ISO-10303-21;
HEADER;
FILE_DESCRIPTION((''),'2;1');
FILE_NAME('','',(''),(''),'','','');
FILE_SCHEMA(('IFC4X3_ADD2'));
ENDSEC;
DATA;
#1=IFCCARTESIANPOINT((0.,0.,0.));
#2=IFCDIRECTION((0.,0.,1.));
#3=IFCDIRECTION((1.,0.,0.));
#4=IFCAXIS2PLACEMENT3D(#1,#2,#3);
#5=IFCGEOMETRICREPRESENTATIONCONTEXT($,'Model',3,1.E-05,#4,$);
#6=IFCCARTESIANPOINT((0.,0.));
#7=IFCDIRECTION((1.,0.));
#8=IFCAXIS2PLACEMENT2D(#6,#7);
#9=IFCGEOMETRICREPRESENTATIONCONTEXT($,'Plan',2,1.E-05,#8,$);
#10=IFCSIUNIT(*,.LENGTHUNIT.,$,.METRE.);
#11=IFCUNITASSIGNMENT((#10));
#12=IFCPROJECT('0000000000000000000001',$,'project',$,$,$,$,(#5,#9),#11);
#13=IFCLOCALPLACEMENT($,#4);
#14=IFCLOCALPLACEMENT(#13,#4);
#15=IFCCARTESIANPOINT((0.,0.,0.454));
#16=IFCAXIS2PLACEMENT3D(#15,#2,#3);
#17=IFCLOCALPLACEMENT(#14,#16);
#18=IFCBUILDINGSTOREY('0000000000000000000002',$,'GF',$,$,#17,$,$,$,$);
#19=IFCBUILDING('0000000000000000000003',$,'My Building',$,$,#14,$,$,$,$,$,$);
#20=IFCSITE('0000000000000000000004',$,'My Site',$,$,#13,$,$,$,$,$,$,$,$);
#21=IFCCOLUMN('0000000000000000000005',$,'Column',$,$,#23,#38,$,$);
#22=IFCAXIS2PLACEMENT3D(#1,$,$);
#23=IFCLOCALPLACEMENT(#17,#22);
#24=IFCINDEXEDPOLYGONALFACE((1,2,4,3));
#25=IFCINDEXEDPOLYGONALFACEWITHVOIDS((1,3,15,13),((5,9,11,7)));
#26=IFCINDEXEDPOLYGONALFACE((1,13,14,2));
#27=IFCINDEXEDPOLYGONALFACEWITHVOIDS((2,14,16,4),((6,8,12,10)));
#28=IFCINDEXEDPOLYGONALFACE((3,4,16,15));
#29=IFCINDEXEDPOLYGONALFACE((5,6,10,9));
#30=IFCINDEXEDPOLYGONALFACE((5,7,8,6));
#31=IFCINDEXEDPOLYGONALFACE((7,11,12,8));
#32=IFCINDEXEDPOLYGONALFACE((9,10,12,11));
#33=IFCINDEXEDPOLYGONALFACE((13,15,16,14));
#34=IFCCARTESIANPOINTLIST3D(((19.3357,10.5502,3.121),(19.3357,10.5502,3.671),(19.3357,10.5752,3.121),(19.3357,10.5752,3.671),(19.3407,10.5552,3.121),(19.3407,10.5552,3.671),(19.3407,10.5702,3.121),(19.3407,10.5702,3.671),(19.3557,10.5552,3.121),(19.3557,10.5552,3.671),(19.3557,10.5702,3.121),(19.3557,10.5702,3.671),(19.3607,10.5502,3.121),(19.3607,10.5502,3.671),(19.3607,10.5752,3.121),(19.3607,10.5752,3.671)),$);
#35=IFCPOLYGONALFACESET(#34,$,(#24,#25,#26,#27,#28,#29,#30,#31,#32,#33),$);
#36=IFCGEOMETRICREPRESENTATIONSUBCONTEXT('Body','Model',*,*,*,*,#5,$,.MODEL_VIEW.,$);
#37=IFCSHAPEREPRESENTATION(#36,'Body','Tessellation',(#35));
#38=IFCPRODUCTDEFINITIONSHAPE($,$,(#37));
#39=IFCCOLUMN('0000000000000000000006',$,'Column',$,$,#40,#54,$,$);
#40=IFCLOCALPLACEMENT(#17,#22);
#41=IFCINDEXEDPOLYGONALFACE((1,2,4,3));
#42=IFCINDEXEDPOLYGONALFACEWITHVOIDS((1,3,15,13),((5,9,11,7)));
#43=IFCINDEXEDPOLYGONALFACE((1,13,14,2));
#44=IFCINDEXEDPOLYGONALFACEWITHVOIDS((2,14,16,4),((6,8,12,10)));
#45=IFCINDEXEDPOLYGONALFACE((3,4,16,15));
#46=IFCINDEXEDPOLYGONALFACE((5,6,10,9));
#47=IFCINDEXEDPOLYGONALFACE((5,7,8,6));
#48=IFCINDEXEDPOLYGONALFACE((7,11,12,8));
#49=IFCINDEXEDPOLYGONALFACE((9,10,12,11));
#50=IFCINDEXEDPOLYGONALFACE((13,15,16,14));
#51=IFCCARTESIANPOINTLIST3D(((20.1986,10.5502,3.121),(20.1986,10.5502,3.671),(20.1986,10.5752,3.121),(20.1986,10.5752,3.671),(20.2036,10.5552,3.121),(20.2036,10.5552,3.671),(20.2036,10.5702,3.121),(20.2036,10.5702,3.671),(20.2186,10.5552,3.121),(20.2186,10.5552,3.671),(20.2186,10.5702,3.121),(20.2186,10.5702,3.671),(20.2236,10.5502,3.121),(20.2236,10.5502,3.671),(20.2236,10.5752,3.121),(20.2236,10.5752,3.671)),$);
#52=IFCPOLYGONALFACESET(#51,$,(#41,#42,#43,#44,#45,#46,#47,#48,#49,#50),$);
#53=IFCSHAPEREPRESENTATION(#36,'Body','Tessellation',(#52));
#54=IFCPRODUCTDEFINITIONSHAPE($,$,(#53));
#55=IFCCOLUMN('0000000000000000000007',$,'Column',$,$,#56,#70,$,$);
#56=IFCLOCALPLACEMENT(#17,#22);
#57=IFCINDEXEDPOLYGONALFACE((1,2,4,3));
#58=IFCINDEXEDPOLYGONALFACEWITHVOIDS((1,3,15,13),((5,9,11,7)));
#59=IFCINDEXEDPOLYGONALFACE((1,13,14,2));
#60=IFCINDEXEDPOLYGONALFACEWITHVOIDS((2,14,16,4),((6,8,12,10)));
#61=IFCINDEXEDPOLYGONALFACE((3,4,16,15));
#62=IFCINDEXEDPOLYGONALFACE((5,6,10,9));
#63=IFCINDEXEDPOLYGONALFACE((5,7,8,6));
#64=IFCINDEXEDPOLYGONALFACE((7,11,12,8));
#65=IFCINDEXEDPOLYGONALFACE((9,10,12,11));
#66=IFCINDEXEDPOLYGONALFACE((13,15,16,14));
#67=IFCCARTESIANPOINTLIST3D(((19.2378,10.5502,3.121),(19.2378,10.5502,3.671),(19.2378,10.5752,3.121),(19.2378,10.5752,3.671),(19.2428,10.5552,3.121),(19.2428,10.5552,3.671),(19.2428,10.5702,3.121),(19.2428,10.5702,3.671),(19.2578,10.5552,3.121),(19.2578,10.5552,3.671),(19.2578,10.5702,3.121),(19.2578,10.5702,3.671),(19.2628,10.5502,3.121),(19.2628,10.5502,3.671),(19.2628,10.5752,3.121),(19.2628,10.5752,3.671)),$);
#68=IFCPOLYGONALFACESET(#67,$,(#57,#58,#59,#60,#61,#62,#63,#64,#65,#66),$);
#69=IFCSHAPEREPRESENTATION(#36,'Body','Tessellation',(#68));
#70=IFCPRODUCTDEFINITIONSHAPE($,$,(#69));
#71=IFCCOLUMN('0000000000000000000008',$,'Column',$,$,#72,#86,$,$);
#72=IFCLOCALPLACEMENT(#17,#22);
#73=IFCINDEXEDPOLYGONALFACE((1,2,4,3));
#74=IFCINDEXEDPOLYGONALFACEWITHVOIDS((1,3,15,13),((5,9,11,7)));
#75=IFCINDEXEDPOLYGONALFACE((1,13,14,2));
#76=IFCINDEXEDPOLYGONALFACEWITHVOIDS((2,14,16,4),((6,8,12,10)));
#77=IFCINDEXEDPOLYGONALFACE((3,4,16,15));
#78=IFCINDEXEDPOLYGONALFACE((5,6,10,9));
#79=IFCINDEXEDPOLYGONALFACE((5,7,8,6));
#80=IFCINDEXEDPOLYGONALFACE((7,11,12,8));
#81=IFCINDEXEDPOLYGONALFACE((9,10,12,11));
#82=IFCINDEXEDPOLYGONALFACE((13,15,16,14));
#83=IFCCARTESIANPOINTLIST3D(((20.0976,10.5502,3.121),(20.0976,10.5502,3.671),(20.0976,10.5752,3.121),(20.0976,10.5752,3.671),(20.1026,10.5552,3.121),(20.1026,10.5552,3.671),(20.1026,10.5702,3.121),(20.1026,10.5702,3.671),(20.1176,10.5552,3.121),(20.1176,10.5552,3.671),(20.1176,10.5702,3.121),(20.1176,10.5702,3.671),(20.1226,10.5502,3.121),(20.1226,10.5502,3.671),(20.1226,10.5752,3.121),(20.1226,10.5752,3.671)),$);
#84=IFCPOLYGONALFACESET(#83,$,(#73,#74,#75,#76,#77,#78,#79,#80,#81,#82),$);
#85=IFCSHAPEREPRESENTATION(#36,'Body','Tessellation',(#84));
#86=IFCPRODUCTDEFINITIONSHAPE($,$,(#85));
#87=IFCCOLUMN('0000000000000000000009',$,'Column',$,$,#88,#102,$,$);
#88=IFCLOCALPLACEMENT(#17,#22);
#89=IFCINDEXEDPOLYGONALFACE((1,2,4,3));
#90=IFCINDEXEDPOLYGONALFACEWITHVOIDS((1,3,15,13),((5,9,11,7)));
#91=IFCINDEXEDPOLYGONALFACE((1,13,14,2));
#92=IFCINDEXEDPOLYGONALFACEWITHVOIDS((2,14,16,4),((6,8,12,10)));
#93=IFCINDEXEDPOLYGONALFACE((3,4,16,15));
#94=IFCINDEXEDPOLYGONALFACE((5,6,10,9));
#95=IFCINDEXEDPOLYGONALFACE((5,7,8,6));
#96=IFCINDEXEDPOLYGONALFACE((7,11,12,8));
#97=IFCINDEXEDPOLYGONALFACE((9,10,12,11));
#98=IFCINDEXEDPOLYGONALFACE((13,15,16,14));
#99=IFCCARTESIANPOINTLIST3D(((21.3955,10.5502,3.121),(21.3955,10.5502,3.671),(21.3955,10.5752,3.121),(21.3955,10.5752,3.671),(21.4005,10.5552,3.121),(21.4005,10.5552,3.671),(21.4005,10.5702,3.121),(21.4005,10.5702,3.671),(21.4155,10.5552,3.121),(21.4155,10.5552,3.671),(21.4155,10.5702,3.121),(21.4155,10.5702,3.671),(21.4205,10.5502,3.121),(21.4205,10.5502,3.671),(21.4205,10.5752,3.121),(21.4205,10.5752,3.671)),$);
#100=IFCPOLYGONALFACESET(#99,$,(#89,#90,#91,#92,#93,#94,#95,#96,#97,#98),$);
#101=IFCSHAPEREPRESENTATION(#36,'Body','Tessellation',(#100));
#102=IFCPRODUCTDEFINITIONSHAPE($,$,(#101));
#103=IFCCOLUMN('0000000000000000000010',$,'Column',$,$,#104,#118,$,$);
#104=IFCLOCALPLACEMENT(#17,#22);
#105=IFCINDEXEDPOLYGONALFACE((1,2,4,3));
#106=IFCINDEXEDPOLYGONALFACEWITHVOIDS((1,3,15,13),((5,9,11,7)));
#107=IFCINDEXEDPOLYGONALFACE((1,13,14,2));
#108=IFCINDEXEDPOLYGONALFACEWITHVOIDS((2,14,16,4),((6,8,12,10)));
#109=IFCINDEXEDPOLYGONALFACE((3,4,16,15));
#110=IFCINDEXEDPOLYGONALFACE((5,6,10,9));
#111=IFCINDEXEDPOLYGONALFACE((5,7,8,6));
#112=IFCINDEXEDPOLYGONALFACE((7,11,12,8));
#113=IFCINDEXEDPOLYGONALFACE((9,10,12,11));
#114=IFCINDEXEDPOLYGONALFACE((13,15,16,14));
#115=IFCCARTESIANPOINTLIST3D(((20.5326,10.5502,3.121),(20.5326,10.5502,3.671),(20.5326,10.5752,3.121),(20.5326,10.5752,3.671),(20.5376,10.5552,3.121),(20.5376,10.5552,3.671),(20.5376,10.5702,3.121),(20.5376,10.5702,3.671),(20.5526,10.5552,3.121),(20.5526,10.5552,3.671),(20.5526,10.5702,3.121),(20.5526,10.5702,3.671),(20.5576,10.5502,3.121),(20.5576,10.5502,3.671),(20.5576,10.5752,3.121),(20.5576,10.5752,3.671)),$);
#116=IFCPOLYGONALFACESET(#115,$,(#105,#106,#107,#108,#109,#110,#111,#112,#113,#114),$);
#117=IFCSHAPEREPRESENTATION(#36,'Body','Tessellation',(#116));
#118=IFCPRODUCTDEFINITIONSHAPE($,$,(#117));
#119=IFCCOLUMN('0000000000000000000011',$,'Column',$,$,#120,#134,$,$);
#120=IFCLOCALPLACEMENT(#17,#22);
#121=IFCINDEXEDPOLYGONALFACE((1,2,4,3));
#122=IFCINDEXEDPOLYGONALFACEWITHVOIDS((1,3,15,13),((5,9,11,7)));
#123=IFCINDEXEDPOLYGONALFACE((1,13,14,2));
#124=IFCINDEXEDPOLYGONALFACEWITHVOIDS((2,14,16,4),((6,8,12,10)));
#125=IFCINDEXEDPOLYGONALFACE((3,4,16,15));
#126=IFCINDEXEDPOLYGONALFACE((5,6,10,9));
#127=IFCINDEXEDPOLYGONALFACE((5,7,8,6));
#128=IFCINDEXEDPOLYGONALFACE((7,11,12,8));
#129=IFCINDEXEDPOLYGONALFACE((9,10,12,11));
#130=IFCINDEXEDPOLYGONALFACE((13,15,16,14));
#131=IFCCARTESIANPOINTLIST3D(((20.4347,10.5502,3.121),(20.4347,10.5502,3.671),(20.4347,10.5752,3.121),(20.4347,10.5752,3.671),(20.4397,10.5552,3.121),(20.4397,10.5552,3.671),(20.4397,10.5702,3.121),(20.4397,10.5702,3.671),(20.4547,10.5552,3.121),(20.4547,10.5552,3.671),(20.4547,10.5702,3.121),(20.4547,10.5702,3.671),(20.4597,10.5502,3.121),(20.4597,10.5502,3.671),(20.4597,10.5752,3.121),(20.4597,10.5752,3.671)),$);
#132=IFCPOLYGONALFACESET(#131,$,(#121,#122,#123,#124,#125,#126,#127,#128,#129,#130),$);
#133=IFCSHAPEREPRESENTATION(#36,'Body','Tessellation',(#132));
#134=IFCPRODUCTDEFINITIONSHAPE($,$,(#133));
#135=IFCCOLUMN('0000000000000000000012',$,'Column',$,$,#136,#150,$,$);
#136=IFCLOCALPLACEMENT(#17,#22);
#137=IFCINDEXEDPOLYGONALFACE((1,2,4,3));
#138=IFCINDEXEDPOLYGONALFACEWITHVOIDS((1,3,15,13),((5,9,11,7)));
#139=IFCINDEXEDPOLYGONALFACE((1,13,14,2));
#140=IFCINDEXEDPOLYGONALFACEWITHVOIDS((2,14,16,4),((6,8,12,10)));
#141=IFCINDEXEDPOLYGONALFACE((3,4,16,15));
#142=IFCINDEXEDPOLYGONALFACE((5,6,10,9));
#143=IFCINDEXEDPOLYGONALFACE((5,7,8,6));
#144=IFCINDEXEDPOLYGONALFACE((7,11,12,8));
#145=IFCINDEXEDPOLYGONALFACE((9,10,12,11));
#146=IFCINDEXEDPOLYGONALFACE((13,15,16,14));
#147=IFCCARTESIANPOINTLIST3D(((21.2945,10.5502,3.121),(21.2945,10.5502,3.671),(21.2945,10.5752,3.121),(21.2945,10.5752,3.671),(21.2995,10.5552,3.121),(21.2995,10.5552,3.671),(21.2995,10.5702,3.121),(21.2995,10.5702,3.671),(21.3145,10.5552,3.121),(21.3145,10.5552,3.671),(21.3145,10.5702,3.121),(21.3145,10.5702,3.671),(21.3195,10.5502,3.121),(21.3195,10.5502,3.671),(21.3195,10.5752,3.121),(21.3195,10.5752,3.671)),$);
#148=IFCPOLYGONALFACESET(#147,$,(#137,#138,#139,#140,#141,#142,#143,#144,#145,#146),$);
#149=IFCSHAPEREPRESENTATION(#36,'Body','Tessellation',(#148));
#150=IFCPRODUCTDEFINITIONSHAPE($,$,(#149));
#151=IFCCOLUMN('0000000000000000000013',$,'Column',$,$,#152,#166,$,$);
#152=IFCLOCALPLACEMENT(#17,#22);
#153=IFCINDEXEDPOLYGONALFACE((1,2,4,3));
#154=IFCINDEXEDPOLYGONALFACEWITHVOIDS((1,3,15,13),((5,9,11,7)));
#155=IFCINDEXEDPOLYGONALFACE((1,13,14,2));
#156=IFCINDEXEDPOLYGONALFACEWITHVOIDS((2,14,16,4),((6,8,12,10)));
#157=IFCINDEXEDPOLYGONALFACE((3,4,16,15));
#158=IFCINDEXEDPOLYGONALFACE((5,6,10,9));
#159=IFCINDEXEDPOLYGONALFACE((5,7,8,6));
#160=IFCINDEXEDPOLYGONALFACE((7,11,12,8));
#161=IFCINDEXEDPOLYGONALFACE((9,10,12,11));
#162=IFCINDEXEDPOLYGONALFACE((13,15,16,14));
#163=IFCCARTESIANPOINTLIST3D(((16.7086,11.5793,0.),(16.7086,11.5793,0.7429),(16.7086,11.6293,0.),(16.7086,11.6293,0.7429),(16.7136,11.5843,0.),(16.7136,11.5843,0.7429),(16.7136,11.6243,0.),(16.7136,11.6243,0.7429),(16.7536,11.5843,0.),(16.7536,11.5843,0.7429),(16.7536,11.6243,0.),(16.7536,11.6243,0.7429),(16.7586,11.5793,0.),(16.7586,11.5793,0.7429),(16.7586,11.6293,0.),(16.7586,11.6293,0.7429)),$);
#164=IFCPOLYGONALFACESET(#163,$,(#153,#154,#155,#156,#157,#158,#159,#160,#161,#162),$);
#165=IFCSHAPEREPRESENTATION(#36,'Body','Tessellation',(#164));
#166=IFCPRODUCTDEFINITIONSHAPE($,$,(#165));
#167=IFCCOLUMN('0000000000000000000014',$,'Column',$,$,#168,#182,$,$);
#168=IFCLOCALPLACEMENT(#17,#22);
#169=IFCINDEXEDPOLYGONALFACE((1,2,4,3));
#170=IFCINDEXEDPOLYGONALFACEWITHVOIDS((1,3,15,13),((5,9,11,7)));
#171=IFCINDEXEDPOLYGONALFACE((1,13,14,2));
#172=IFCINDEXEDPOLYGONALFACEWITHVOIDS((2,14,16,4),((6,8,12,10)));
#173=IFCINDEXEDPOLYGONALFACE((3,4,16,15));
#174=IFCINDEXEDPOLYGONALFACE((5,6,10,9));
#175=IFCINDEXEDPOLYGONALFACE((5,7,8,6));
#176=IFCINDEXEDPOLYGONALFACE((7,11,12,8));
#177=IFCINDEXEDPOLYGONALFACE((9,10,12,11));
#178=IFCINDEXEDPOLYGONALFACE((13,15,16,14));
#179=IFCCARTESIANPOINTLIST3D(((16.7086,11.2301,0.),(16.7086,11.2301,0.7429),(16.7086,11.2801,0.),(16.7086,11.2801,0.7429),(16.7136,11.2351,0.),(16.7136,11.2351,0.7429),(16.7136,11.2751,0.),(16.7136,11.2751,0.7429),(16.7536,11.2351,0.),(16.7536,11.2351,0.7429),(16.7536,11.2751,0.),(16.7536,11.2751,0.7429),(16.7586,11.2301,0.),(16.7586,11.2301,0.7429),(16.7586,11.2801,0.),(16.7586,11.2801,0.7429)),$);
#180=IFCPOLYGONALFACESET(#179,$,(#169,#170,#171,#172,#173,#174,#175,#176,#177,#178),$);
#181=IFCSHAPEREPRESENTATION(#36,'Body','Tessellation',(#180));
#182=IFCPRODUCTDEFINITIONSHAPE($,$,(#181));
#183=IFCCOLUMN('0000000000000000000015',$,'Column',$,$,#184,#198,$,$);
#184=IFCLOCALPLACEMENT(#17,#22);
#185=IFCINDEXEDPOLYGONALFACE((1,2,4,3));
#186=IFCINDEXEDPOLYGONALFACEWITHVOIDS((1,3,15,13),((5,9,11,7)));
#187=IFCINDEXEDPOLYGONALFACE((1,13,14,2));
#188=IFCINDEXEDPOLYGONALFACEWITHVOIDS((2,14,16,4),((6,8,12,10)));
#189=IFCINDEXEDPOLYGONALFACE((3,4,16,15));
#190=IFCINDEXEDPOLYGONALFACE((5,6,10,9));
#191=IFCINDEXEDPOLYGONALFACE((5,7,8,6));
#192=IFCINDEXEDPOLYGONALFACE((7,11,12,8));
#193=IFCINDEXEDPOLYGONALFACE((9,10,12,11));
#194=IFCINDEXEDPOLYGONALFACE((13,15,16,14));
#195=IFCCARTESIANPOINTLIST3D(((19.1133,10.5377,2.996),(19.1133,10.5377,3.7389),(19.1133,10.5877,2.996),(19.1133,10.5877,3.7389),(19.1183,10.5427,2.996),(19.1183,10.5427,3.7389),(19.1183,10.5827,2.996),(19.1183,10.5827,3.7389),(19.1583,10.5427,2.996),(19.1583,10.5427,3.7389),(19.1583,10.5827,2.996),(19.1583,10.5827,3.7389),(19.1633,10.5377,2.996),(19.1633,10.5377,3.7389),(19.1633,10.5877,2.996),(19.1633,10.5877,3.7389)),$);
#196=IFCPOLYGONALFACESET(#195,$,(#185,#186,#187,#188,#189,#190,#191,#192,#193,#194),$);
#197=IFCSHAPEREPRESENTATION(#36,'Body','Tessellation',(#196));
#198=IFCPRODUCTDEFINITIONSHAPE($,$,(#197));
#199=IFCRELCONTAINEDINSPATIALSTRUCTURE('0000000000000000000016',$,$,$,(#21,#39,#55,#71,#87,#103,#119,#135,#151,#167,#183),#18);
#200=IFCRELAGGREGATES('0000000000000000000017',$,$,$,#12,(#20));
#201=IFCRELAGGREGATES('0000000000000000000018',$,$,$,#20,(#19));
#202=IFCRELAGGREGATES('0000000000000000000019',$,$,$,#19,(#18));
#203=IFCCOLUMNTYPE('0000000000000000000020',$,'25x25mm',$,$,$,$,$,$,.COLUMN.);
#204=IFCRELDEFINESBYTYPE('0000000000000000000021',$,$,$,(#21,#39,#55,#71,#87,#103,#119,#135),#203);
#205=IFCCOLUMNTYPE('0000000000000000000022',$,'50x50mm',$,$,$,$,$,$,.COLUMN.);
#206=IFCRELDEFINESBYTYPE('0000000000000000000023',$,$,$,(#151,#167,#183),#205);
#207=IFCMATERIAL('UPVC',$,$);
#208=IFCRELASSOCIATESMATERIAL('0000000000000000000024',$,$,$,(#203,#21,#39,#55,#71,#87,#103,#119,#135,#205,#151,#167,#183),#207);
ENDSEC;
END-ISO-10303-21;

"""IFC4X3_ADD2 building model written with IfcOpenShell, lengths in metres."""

from ifc_helpers import new_model, si_unit, frame, origin_with_axes, origin_2d_with_axis, place, context, subcontext, project, spatial, hollow_rectangle, extrude, material, material_profile, profile_set, profile_usage, type_object, element, save


model = new_model("IFC4X3_ADD2")

# Units and contexts
model_context = context("Model", 3, precision=1e-05, world=origin_with_axes())
plan_context = context("Plan", 2, precision=1e-05, world=origin_2d_with_axis())
body_context = subcontext(model_context, "Body", "Model", "MODEL_VIEW")
ifc_project = project(units=[si_unit("LENGTHUNIT", "METRE")], contexts=[model_context, plan_context])

# Site, building, storey
site_placement = place(None, origin_with_axes())
site = spatial("IfcSite", under=ifc_project, at=site_placement, Name="My Site")
building_placement = place(site_placement, origin_with_axes())
building = spatial("IfcBuilding", under=site, at=building_placement, Name="My Building")
storey_placement = place(building_placement, frame((0.0, 0.0, 0.454), z_axis=(0.0, 0.0, 1.0), x_axis=(1.0, 0.0, 0.0)))
storey = spatial("IfcBuildingStorey", under=building, at=storey_placement, Name="GF")

# Columns
ifc_material_1 = material(Name="UPVC")
ifc_material_profile_1 = material_profile(ifc_material_1, hollow_rectangle(XDim=0.025, YDim=0.025, WallThickness=0.005))
ifc_profile_set_1 = profile_set([ifc_material_profile_1])
column_type_1 = type_object("IfcColumnType", Name="25x25mm", PredefinedType="COLUMN", material=ifc_profile_set_1)
ifc_profile_usage_1 = profile_usage(ifc_profile_set_1)
column_1_placement = place(storey_placement, frame((19.3482, 10.5627, 3.121), z_axis=(0.0, 0.0, 1.0), x_axis=(0.0, -1.0, 0.0)))
element("IfcColumn", 1, at=column_1_placement, inside=storey, type_object=column_type_1, material=ifc_profile_usage_1, Name="Column", context=body_context, shape_type="SweptSolid", body=[
    extrude(hollow_rectangle(XDim=0.025, YDim=0.025, WallThickness=0.005), origin_with_axes(), (0.0, 0.0, 1.0), 0.55),
])
ifc_profile_usage_2 = profile_usage(ifc_profile_set_1)
column_2_placement = place(storey_placement, frame((20.2111, 10.5627, 3.121), z_axis=(0.0, 0.0, 1.0), x_axis=(0.0, -1.0, 0.0)))
element("IfcColumn", 2, at=column_2_placement, inside=storey, type_object=column_type_1, material=ifc_profile_usage_2, Name="Column", context=body_context, shape_type="SweptSolid", body=[
    extrude(hollow_rectangle(XDim=0.025, YDim=0.025, WallThickness=0.005), origin_with_axes(), (0.0, 0.0, 1.0), 0.55),
])
ifc_profile_usage_3 = profile_usage(ifc_profile_set_1)
column_3_placement = place(storey_placement, frame((19.2503, 10.5627, 3.121), z_axis=(0.0, 0.0, 1.0), x_axis=(0.0, -1.0, 0.0)))
element("IfcColumn", 3, at=column_3_placement, inside=storey, type_object=column_type_1, material=ifc_profile_usage_3, Name="Column", context=body_context, shape_type="SweptSolid", body=[
    extrude(hollow_rectangle(XDim=0.025, YDim=0.025, WallThickness=0.005), origin_with_axes(), (0.0, 0.0, 1.0), 0.55),
])
ifc_profile_usage_4 = profile_usage(ifc_profile_set_1)
column_4_placement = place(storey_placement, frame((20.1101, 10.5627, 3.121), z_axis=(0.0, 0.0, 1.0), x_axis=(0.0, -1.0, 0.0)))
element("IfcColumn", 4, at=column_4_placement, inside=storey, type_object=column_type_1, material=ifc_profile_usage_4, Name="Column", context=body_context, shape_type="SweptSolid", body=[
    extrude(hollow_rectangle(XDim=0.025, YDim=0.025, WallThickness=0.005), origin_with_axes(), (0.0, 0.0, 1.0), 0.55),
])
ifc_profile_usage_5 = profile_usage(ifc_profile_set_1)
column_5_placement = place(storey_placement, frame((21.408, 10.5627, 3.121), z_axis=(0.0, 0.0, 1.0), x_axis=(0.0, -1.0, 0.0)))
element("IfcColumn", 5, at=column_5_placement, inside=storey, type_object=column_type_1, material=ifc_profile_usage_5, Name="Column", context=body_context, shape_type="SweptSolid", body=[
    extrude(hollow_rectangle(XDim=0.025, YDim=0.025, WallThickness=0.005), origin_with_axes(), (0.0, 0.0, 1.0), 0.55),
])
ifc_profile_usage_6 = profile_usage(ifc_profile_set_1)
column_6_placement = place(storey_placement, frame((20.5451, 10.5627, 3.121), z_axis=(0.0, 0.0, 1.0), x_axis=(0.0, -1.0, 0.0)))
element("IfcColumn", 6, at=column_6_placement, inside=storey, type_object=column_type_1, material=ifc_profile_usage_6, Name="Column", context=body_context, shape_type="SweptSolid", body=[
    extrude(hollow_rectangle(XDim=0.025, YDim=0.025, WallThickness=0.005), origin_with_axes(), (0.0, 0.0, 1.0), 0.55),
])
ifc_profile_usage_7 = profile_usage(ifc_profile_set_1)
column_7_placement = place(storey_placement, frame((20.4472, 10.5627, 3.121), z_axis=(0.0, 0.0, 1.0), x_axis=(0.0, -1.0, 0.0)))
element("IfcColumn", 7, at=column_7_placement, inside=storey, type_object=column_type_1, material=ifc_profile_usage_7, Name="Column", context=body_context, shape_type="SweptSolid", body=[
    extrude(hollow_rectangle(XDim=0.025, YDim=0.025, WallThickness=0.005), origin_with_axes(), (0.0, 0.0, 1.0), 0.55),
])
ifc_profile_usage_8 = profile_usage(ifc_profile_set_1)
column_8_placement = place(storey_placement, frame((21.307, 10.5627, 3.121), z_axis=(0.0, 0.0, 1.0), x_axis=(0.0, -1.0, 0.0)))
element("IfcColumn", 8, at=column_8_placement, inside=storey, type_object=column_type_1, material=ifc_profile_usage_8, Name="Column", context=body_context, shape_type="SweptSolid", body=[
    extrude(hollow_rectangle(XDim=0.025, YDim=0.025, WallThickness=0.005), origin_with_axes(), (0.0, 0.0, 1.0), 0.55),
])
ifc_material_profile_2 = material_profile(ifc_material_1, hollow_rectangle(XDim=0.05, YDim=0.05, WallThickness=0.005))
ifc_profile_set_2 = profile_set([ifc_material_profile_2])
ifc_profile_usage_9 = profile_usage(ifc_profile_set_2)
column_type_2 = type_object("IfcColumnType", Name="50x50mm", PredefinedType="COLUMN", material=ifc_profile_set_2)
column_9_placement = place(storey_placement, frame((16.7336, 11.6043, 0.0), z_axis=(0.0, 0.0, 1.0), x_axis=(0.0, -1.0, 0.0)))
element("IfcColumn", 9, at=column_9_placement, inside=storey, type_object=column_type_2, material=ifc_profile_usage_9, Name="Column", context=body_context, shape_type="SweptSolid", body=[
    extrude(hollow_rectangle(XDim=0.05, YDim=0.05, WallThickness=0.005), origin_with_axes(), (0.0, 0.0, 1.0), 0.7429),
])
ifc_profile_usage_10 = profile_usage(ifc_profile_set_2)
column_10_placement = place(storey_placement, frame((16.7336, 11.2551, 0.0), z_axis=(0.0, 0.0, 1.0), x_axis=(0.0, -1.0, 0.0)))
element("IfcColumn", 10, at=column_10_placement, inside=storey, type_object=column_type_2, material=ifc_profile_usage_10, Name="Column", context=body_context, shape_type="SweptSolid", body=[
    extrude(hollow_rectangle(XDim=0.05, YDim=0.05, WallThickness=0.005), origin_with_axes(), (0.0, 0.0, 1.0), 0.7429),
])
ifc_profile_usage_11 = profile_usage(ifc_profile_set_2)
column_11_placement = place(storey_placement, frame((19.1383, 10.5627, 2.996), z_axis=(0.0, 0.0, 1.0), x_axis=(1.0, 0.0, 0.0)))
element("IfcColumn", 11, at=column_11_placement, inside=storey, type_object=column_type_2, material=ifc_profile_usage_11, Name="Column", context=body_context, shape_type="SweptSolid", body=[
    extrude(hollow_rectangle(XDim=0.05, YDim=0.05, WallThickness=0.005), origin_with_axes(), (0.0, 0.0, 1.0), 0.7429),
])

save(model, "model.ifc")
